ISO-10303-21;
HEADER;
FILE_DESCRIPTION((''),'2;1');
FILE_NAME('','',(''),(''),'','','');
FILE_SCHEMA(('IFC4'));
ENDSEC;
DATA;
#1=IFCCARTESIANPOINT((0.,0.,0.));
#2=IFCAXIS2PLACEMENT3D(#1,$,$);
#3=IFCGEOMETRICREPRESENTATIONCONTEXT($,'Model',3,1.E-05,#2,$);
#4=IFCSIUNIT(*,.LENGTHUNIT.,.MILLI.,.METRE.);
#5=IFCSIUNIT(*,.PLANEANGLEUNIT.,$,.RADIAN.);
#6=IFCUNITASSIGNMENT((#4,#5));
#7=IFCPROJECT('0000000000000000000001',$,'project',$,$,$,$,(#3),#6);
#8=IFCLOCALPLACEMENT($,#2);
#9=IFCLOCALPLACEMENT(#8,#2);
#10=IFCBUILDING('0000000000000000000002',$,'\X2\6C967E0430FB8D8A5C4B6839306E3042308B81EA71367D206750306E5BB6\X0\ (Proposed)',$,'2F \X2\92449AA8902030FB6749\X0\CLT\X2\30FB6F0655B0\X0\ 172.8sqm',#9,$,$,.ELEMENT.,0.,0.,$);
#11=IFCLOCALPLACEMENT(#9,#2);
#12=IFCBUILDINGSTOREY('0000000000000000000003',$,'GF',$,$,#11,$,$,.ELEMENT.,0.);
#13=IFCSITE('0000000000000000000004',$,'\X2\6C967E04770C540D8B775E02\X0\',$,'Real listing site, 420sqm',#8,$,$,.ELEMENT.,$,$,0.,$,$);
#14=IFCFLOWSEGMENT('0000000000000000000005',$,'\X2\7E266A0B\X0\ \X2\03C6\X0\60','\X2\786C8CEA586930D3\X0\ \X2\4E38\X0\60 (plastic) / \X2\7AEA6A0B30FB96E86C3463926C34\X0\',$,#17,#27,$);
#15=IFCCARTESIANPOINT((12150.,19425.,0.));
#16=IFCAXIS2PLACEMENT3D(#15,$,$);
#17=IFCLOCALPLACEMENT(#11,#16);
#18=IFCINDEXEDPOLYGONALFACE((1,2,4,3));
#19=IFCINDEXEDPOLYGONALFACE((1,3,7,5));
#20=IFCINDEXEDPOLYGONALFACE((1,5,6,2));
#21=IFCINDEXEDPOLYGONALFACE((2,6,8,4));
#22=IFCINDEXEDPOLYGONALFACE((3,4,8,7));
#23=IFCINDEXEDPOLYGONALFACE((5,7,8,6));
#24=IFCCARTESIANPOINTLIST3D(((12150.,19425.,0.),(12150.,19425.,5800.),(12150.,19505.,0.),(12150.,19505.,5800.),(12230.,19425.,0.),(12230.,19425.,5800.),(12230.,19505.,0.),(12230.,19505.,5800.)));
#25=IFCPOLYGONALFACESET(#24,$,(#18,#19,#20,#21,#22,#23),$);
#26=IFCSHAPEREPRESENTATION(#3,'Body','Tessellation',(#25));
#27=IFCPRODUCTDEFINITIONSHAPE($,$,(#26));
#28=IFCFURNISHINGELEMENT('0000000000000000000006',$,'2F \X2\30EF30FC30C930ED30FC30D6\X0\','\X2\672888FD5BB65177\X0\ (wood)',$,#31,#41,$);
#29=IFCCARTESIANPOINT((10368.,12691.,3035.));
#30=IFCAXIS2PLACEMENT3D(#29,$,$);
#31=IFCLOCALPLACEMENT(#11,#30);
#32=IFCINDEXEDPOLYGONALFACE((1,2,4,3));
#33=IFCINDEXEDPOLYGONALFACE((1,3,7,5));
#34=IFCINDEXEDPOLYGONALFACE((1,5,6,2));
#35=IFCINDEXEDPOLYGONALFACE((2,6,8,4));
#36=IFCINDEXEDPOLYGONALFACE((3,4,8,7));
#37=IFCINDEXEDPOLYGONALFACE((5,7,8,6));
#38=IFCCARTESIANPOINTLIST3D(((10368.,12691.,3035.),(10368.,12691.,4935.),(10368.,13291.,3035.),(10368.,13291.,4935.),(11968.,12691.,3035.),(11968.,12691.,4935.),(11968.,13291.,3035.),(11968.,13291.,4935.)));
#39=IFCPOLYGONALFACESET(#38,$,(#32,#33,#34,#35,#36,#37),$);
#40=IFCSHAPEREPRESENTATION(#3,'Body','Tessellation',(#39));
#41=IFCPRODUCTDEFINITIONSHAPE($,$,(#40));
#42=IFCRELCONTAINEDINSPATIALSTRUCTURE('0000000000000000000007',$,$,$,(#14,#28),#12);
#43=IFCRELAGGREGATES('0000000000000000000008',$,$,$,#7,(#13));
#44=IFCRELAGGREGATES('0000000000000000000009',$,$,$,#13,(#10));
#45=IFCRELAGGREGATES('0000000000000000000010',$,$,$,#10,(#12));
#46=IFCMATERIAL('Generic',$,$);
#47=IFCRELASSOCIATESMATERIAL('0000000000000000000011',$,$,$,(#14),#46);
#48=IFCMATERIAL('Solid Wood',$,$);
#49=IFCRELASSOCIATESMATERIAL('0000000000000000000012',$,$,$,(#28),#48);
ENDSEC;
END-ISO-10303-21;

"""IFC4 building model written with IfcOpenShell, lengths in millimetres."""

from ifc_helpers import new_model, si_unit, frame, frame_2d, origin, place, context, project, spatial, rectangle, extrude, material, element, save


model = new_model("IFC4")

# Units and contexts
model_context = context("Model", 3, precision=1e-05, world=origin())
ifc_project = project(units=[si_unit("LENGTHUNIT", "METRE", prefix="MILLI"), si_unit("PLANEANGLEUNIT", "RADIAN")], contexts=[model_context])

# Site, building, storey
site_placement = place(None, origin())
site = spatial("IfcSite", under=ifc_project, at=site_placement, Name="沖縄県名護市", ObjectType="Real listing site, 420sqm", CompositionType="ELEMENT", RefElevation=0.0)
building_placement = place(site_placement, origin())
building = spatial("IfcBuilding", under=site, at=building_placement, Name="沖縄・越屋根のある自然素材の家 (Proposed)", ObjectType="2F 鉄骨造・杉CLT・漆喰 172.8sqm", CompositionType="ELEMENT", ElevationOfRefHeight=0.0, ElevationOfTerrain=0.0)
storey_placement = place(building_placement, origin())
storey = spatial("IfcBuildingStorey", under=building, at=storey_placement, Name="GF", CompositionType="ELEMENT", Elevation=0.0)

# Shared definitions
ifc_material_1 = material(Name="Solid Wood")

# Shared definitions
ifc_material_2 = material(Name="Generic")

# Flow segment
flow_segment_placement = place(storey_placement, frame((12150.0, 19425.0, 0.0)))
element("IfcFlowSegment", 1, at=flow_segment_placement, inside=storey, material=ifc_material_2, Name="縦樋 φ60", Description="硬質塩ビ 丸60 (plastic) / 竪樋・雨水排水", context=model_context, shape_type="SweptSolid", body=[
    extrude(rectangle(XDim=80.0, YDim=80.0, at=frame_2d((40.0, 40.0))), frame((12150.0, 19425.0, 0.0)), (0.0, 0.0, 1.0), 5800.0),
])

# Furnishing element
furnishing_placement = place(storey_placement, frame((10368.0, 12691.0, 3035.0)))
element("IfcFurnishingElement", 2, at=furnishing_placement, inside=storey, material=ifc_material_1, Name="2F ワードローブ", Description="木製家具 (wood)", context=model_context, shape_type="SweptSolid", body=[
    extrude(rectangle(XDim=1600.0, YDim=600.0, at=frame_2d((800.0, 300.0))), frame((10368.0, 12691.0, 3035.0)), (0.0, 0.0, 1.0), 1900.0),
])

save(model, "model.ifc")
